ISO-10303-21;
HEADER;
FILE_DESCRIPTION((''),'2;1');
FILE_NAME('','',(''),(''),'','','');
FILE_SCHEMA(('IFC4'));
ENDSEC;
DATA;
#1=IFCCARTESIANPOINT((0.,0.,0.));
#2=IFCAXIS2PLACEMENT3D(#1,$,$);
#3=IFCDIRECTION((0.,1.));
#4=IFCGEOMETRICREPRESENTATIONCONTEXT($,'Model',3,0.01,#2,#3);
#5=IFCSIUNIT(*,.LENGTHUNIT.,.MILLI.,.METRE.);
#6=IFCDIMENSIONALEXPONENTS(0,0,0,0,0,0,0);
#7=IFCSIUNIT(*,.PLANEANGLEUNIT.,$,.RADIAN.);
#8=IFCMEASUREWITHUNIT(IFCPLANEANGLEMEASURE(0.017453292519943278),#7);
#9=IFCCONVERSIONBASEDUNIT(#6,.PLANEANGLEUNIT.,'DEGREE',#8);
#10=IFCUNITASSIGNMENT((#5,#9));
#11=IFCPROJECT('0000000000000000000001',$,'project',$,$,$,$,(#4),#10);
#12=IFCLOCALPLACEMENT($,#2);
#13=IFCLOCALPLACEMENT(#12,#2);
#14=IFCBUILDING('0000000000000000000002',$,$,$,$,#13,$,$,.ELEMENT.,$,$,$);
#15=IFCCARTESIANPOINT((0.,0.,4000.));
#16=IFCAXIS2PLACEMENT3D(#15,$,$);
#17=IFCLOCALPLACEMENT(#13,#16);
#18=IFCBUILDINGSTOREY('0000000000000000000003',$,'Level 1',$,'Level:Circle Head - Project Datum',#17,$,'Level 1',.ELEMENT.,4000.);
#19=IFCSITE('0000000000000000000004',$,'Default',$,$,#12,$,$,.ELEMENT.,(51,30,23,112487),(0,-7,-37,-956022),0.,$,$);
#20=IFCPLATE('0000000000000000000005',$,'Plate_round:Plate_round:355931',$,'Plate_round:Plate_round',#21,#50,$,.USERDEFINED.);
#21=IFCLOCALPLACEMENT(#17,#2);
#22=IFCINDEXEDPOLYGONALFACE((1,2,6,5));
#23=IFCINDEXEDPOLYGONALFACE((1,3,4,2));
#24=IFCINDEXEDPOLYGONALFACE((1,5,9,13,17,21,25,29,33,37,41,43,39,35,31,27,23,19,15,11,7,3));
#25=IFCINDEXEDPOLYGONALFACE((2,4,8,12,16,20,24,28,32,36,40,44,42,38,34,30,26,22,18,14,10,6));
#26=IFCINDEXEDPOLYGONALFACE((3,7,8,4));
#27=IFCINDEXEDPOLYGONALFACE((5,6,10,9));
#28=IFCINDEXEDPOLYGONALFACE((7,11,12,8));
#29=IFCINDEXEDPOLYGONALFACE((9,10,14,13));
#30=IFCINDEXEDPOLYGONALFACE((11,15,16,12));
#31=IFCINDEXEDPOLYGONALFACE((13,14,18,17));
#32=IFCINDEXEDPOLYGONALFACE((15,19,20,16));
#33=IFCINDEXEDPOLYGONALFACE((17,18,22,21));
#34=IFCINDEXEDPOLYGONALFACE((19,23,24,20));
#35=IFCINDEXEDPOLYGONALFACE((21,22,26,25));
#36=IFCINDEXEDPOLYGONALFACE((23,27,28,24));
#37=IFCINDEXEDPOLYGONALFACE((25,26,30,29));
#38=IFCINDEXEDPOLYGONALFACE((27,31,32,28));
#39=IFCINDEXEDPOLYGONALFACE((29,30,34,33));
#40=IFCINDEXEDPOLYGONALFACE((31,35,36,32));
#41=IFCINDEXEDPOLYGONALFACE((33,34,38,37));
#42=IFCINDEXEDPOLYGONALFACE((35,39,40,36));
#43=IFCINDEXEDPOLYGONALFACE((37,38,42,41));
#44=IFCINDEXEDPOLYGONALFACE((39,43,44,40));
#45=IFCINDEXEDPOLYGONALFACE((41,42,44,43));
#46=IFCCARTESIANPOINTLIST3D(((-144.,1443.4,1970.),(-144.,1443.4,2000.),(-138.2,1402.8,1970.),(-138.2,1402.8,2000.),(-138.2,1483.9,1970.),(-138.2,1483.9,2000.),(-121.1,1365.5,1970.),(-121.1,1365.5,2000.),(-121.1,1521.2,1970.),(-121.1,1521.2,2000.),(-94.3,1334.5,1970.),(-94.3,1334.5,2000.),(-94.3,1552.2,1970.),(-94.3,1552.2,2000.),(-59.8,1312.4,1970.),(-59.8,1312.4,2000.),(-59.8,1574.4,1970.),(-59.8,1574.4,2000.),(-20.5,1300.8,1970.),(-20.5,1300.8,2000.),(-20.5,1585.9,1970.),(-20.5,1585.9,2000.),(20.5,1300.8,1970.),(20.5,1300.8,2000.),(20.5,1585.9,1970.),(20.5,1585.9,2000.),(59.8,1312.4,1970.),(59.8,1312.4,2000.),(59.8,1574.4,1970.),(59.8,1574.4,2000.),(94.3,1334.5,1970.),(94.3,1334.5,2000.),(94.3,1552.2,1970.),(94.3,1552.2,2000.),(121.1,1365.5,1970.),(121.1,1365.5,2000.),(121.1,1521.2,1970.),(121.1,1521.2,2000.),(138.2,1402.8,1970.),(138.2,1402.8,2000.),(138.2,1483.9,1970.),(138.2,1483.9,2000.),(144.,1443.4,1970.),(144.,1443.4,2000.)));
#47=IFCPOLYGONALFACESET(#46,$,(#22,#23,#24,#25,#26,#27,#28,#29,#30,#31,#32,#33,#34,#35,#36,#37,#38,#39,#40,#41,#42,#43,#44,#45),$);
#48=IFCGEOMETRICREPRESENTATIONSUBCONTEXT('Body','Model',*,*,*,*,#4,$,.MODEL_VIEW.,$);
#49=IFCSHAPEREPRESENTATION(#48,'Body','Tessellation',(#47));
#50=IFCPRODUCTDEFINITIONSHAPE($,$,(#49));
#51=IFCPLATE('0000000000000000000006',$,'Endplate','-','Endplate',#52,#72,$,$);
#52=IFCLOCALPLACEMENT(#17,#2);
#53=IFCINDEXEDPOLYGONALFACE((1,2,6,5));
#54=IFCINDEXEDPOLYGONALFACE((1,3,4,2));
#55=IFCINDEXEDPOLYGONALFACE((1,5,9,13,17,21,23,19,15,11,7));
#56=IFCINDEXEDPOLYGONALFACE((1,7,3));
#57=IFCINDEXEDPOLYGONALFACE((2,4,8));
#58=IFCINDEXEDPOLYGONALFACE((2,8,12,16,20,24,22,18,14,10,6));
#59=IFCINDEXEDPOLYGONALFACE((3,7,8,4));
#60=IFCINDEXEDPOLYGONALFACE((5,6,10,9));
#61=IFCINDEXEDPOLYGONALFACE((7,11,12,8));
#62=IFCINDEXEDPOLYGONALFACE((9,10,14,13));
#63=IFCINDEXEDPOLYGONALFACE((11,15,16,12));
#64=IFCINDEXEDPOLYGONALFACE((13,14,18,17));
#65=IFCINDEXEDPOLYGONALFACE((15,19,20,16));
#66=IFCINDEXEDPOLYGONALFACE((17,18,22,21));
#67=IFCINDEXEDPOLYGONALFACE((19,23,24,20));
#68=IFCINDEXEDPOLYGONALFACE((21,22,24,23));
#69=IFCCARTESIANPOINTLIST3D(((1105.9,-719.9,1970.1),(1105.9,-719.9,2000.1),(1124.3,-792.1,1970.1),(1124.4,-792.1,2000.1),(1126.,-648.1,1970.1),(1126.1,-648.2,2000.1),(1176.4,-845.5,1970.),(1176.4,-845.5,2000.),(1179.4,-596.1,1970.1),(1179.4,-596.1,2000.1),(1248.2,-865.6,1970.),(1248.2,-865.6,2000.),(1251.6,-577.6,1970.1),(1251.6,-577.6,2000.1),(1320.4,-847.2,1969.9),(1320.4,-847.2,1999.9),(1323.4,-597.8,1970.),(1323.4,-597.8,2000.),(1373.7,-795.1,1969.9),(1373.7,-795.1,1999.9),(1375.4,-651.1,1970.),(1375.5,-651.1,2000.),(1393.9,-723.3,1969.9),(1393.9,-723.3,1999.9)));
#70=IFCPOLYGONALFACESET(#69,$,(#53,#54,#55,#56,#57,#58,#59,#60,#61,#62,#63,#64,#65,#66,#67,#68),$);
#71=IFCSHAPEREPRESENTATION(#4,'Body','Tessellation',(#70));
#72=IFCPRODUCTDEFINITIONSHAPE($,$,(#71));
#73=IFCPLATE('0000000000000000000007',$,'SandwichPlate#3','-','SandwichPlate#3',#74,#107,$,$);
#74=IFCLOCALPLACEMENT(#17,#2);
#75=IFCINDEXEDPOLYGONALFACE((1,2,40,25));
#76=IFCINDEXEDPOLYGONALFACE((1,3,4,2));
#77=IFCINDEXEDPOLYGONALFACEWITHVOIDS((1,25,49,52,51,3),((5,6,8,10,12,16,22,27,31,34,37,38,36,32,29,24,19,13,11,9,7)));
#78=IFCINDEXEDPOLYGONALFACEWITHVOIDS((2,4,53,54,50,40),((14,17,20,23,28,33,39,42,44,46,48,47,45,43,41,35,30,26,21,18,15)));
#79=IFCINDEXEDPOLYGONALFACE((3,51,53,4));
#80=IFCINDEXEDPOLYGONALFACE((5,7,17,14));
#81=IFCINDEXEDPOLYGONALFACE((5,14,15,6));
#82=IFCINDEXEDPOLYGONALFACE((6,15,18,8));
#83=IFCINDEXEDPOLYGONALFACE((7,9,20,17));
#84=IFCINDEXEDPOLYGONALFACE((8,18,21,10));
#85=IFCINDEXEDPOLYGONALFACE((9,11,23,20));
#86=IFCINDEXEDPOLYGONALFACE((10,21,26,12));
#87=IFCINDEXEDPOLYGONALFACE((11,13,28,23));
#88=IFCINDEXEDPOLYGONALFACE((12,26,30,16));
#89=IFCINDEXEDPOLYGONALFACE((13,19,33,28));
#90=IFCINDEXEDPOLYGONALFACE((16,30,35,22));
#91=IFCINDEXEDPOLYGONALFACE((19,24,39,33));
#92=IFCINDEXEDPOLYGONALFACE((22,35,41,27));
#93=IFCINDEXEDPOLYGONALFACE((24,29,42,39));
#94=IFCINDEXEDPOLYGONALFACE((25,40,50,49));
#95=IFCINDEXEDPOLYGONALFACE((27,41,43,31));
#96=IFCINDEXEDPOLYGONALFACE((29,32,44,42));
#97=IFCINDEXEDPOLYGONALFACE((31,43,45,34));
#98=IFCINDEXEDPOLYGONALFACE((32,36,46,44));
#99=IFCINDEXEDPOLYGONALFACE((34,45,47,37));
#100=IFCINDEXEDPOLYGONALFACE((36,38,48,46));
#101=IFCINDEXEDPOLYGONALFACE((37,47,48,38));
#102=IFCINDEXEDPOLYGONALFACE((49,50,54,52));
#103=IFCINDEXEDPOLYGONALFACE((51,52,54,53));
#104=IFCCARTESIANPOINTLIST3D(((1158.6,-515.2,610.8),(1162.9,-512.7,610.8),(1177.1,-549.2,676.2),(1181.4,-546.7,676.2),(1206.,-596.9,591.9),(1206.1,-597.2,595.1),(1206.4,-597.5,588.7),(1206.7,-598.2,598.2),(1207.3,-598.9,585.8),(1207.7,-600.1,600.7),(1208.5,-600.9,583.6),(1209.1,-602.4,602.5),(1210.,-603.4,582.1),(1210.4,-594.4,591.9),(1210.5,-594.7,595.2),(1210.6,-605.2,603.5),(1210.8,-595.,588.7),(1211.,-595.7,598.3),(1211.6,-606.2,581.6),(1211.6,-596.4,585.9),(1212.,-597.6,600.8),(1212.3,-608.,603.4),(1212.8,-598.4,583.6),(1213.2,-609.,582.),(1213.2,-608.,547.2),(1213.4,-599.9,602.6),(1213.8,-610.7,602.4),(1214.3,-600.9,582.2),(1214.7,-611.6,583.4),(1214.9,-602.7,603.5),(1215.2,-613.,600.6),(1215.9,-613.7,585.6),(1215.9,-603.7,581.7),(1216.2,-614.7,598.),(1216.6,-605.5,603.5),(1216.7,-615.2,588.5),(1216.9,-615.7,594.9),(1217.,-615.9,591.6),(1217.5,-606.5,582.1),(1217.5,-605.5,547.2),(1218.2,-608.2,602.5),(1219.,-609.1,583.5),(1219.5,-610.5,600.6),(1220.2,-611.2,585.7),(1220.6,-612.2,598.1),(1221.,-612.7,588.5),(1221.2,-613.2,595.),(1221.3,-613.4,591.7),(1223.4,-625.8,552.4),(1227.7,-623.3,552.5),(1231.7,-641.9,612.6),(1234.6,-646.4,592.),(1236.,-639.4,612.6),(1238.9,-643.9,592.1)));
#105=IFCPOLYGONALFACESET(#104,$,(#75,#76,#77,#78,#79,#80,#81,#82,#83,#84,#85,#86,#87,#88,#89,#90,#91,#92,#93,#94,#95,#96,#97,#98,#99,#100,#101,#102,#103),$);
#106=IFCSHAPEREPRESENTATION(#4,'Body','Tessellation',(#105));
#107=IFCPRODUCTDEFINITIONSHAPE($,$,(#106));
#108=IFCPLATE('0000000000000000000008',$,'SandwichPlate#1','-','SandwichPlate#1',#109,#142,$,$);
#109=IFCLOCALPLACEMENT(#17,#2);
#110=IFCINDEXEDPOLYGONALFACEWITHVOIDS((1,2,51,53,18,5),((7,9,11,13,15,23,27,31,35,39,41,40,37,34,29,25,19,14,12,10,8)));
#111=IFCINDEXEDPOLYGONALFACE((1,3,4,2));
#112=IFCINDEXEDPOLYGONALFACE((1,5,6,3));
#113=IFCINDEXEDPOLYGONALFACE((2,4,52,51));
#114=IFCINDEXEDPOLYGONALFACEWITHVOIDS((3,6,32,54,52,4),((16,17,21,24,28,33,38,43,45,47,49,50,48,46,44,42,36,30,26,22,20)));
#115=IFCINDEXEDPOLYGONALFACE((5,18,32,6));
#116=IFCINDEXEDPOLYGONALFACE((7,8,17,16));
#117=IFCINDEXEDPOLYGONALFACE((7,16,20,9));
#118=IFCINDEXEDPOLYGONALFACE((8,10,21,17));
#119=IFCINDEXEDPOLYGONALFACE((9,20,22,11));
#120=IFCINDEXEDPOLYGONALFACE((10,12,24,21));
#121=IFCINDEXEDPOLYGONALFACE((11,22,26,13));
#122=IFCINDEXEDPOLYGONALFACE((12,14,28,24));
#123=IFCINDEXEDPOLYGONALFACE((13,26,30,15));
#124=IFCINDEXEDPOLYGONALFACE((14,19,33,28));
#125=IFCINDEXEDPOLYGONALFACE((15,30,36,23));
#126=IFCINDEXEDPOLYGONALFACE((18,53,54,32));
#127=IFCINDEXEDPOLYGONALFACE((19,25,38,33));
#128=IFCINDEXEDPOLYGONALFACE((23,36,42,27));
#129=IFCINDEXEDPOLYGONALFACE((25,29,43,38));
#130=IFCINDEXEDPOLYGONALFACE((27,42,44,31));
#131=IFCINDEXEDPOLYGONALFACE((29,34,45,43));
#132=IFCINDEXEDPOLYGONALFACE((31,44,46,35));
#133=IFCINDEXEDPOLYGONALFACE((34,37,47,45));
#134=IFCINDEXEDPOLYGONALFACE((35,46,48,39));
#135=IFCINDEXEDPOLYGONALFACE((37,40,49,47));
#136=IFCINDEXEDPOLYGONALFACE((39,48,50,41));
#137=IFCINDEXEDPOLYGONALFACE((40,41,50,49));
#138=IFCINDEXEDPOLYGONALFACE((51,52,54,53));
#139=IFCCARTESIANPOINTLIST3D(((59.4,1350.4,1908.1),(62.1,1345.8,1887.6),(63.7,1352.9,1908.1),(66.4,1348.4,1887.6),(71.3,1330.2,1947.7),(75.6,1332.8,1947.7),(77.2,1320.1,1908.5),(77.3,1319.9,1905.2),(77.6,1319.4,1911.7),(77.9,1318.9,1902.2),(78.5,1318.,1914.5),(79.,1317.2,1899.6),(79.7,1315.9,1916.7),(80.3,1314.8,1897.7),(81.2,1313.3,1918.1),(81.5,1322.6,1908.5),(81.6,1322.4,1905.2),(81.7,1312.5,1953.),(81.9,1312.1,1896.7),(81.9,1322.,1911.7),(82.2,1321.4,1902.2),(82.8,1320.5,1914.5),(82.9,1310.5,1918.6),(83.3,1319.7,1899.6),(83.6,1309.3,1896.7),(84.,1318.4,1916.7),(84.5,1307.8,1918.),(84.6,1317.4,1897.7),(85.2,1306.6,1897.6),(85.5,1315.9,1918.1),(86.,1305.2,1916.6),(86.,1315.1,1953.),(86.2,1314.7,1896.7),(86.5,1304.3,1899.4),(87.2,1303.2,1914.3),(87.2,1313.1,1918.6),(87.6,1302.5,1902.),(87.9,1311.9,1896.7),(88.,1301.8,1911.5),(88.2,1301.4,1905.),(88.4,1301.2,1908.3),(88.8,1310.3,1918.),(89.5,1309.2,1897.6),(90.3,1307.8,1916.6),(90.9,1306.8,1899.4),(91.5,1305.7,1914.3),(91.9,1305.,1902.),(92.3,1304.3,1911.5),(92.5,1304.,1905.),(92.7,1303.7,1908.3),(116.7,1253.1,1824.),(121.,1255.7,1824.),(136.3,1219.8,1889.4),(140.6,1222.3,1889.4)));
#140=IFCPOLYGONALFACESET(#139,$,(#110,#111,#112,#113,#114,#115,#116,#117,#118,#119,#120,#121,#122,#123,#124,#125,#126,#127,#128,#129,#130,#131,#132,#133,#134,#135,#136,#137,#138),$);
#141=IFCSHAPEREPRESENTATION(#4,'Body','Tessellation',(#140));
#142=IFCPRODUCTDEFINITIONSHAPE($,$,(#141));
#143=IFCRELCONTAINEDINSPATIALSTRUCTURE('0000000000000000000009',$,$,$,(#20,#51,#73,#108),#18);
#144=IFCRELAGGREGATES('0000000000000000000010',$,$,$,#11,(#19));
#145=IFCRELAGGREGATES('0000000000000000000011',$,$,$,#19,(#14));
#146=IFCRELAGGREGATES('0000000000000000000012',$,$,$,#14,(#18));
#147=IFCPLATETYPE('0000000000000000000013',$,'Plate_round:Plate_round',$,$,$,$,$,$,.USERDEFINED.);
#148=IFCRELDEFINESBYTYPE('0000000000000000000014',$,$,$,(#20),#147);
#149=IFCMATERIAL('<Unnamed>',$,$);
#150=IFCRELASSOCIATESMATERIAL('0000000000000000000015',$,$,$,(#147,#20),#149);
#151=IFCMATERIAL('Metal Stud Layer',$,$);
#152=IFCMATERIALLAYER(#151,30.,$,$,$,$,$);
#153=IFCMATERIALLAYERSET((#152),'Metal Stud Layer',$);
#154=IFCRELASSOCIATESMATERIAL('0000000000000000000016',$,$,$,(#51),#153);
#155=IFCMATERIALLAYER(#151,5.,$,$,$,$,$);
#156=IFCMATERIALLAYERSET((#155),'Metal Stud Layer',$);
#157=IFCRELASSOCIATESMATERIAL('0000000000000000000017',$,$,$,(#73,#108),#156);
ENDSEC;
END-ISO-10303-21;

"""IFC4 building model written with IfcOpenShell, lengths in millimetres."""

from ifc_helpers import new_model, entity, si_unit, converted_unit, point, direction, frame, frame_2d, origin, origin_with_axes, origin_2d_with_axis, place, context, subcontext, project, spatial, polyline, arc, indexed_curve, circle_curve, line_curve, trimmed, segment, composite_curve, circle, outline, extrude, source, transform, mapped, material, layer, layer_set, type_object, type_shapes, element, save


model = new_model("IFC4")

# Units and contexts
model_context = context("Model", 3, precision=0.01, world=origin(), true_north=direction((0.0, 1.0)))
body_context = subcontext(model_context, "Body", "Model", "MODEL_VIEW")
ifc_project = project(units=[si_unit("LENGTHUNIT", "METRE", prefix="MILLI"), converted_unit("PLANEANGLEUNIT", "DEGREE", entity("IfcPlaneAngleMeasure", 0.017453292519943278), si_unit("PLANEANGLEUNIT", "RADIAN"), dimensions=[0, 0, 0, 0, 0, 0, 0])], contexts=[model_context])

# Site, building, storey
site_placement = place(None, origin())
site = spatial("IfcSite", under=ifc_project, at=site_placement, Name="Default", CompositionType="ELEMENT", RefLatitude=(51, 30, 23, 112487), RefLongitude=(0, -7, -37, -956022), RefElevation=0.0)
building_placement = place(site_placement, origin())
building = spatial("IfcBuilding", under=site, at=building_placement, CompositionType="ELEMENT")
storey_placement = place(building_placement, frame((0.0, 0.0, 4000.0)))
storey = spatial("IfcBuildingStorey", under=building, at=storey_placement, Name="Level 1", ObjectType="Level:Circle Head - Project Datum", LongName="Level 1", CompositionType="ELEMENT", Elevation=4000.0)

# Plate
ifc_material_1 = material(Name="<Unnamed>")
plate_type = type_object("IfcPlateType", Name="Plate_round:Plate_round", PredefinedType="USERDEFINED", material=ifc_material_1)
shared_shape = source(origin(), body_context, "Body", "SweptSolid", [
    extrude(outline(indexed_curve([(-144.0, 0.0), (0.0, -144.0), (144.0, 0.0), (0.0, 144.0)], segments=[arc(1, 2, 3), arc(3, 4, 1)], self_intersect=False)), origin(), (0.0, 0.0, 1.0), 30.0),
])
type_shapes(plate_type, [shared_shape])
plate_1_placement = place(storey_placement, frame((0.0, 1443.4, 1970.0)))
element("IfcPlate", 1, at=plate_1_placement, inside=storey, type_object=plate_type, material=ifc_material_1, Name="Plate_round:Plate_round:355931", ObjectType="Plate_round:Plate_round", PredefinedType="USERDEFINED", context=body_context, shape_type="MappedRepresentation", body=[
    mapped(shared_shape, transform((0.0, 0.0, 0.0), scale=1.0)),
])

# Plates, openings
ifc_material_2 = material(Name="Metal Stud Layer")
ifc_layer_1 = layer(ifc_material_2, 30.0)
ifc_layer_set_1 = layer_set([ifc_layer_1], Name="Metal Stud Layer")
plate_2_placement = place(storey_placement, frame((1323.4, -597.8, 1970.0), z_axis=(0.000702, -0.000406, 1.0), x_axis=(-0.860023, 0.510255, 0.000811)))
plate_2 = element("IfcPlate", 2, at=plate_2_placement, inside=storey, material=ifc_layer_set_1, Name="Endplate", Description="-", ObjectType="Endplate", context=model_context, shape_type="SweptSolid", body=[
    extrude(outline(polyline([(144.0, 0.0), (144.0, 288.0), (-144.0, 288.0), (-144.0, 0.0), (144.0, 0.0)])), origin_with_axes(), (0.0, 0.0, 1.0), 30.0),
])
opening_1_placement = place(plate_2_placement, frame((0.0, 0.0, 0.0), z_axis=(0.0, 0.0, 1.0), x_axis=(1.0, 0.0, 0.0)))
element("IfcOpeningElement", 3, at=opening_1_placement, cuts=plate_2, ObjectType="Opening", context=model_context, shape_type="SweptSolid", body=[
    extrude(outline(composite_curve([segment(trimmed(line_curve((144.0, 0.0), (0.0, 1.0), 144.0), [point((144.0, 0.0))], [point((144.0, 144.0))], True, "CARTESIAN"), True, "CONTINUOUS"), segment(trimmed(circle_curve(frame_2d((0.0, 144.0), x_axis=(-1.0, 0.0)), 144.0), [point((144.0, 144.0))], [point((0.0, 0.0))], False, "CARTESIAN"), True, "CONTINUOUS"), segment(trimmed(line_curve((0.0, 0.0), (1.0, 0.0), 144.0), [point((0.0, 0.0))], [point((144.0, 0.0))], True, "CARTESIAN"), True, "CONTINUOUS")], self_intersect="UNKNOWN")), origin(), (0.0, 0.0, 1.0), 30.0),
])
opening_2_placement = place(plate_2_placement, frame((0.0, 0.0, 0.0), z_axis=(0.0, 0.0, 1.0), x_axis=(1.0, 0.0, 0.0)))
element("IfcOpeningElement", 4, at=opening_2_placement, cuts=plate_2, ObjectType="Opening", context=model_context, shape_type="SweptSolid", body=[
    extrude(outline(composite_curve([segment(trimmed(line_curve((144.0, 288.0), (-1.0, 0.0), 144.0), [point((144.0, 288.0))], [point((0.0, 288.0))], True, "CARTESIAN"), True, "CONTINUOUS"), segment(trimmed(circle_curve(frame_2d((0.0, 144.0), x_axis=(-1.0, 0.0)), 144.0), [point((0.0, 288.0))], [point((144.0, 144.0))], False, "CARTESIAN"), True, "CONTINUOUS"), segment(trimmed(line_curve((144.0, 144.0), (0.0, 1.0), 144.0), [point((144.0, 144.0))], [point((144.0, 288.0))], True, "CARTESIAN"), True, "CONTINUOUS")], self_intersect="UNKNOWN")), origin(), (0.0, 0.0, 1.0), 30.0),
])
opening_3_placement = place(plate_2_placement, frame((0.0, 0.0, 0.0), z_axis=(0.0, 0.0, 1.0), x_axis=(1.0, 0.0, 0.0)))
element("IfcOpeningElement", 5, at=opening_3_placement, cuts=plate_2, ObjectType="Opening", context=model_context, shape_type="SweptSolid", body=[
    extrude(outline(composite_curve([segment(trimmed(line_curve((-144.0, 288.0), (0.0, -1.0), 144.0), [point((-144.0, 288.0))], [point((-144.0, 144.0))], True, "CARTESIAN"), True, "CONTINUOUS"), segment(trimmed(circle_curve(frame_2d((0.0, 144.0), x_axis=(-1.0, 0.0)), 144.0), [point((-144.0, 144.0))], [point((0.0, 288.0))], False, "CARTESIAN"), True, "CONTINUOUS"), segment(trimmed(line_curve((0.0, 288.0), (-1.0, 0.0), 144.0), [point((0.0, 288.0))], [point((-144.0, 288.0))], True, "CARTESIAN"), True, "CONTINUOUS")], self_intersect="UNKNOWN")), origin(), (0.0, 0.0, 1.0), 30.0),
])
opening_4_placement = place(plate_2_placement, frame((0.0, 0.0, 0.0), z_axis=(0.0, 0.0, 1.0), x_axis=(1.0, 0.0, 0.0)))
element("IfcOpeningElement", 6, at=opening_4_placement, cuts=plate_2, ObjectType="Opening", context=model_context, shape_type="SweptSolid", body=[
    extrude(outline(composite_curve([segment(trimmed(line_curve((-144.0, 0.0), (1.0, 0.0), 144.0), [point((-144.0, 0.0))], [point((0.0, 0.0))], True, "CARTESIAN"), True, "CONTINUOUS"), segment(trimmed(circle_curve(frame_2d((0.0, 144.0), x_axis=(-1.0, 0.0)), 144.0), [point((0.0, 0.0))], [point((-144.0, 144.0))], False, "CARTESIAN"), True, "CONTINUOUS"), segment(trimmed(line_curve((-144.0, 144.0), (0.0, -1.0), 144.0), [point((-144.0, 144.0))], [point((-144.0, 0.0))], True, "CARTESIAN"), True, "CONTINUOUS")], self_intersect="UNKNOWN")), origin(), (0.0, 0.0, 1.0), 30.0),
])
ifc_layer_2 = layer(ifc_material_2, 5.0)
ifc_layer_set_2 = layer_set([ifc_layer_2], Name="Metal Stud Layer")
plate_3_placement = place(storey_placement, frame((1224.1, -616.6, 539.6), z_axis=(-0.865935, -0.499948, -0.014432), x_axis=(0.243701, -0.44695, 0.860724)))
plate_3 = element("IfcPlate", 7, at=plate_3_placement, inside=storey, material=ifc_layer_set_2, Name="SandwichPlate#3", Description="-", ObjectType="SandwichPlate#3", context=model_context, shape_type="SweptSolid", body=[
    extrude(outline(polyline([(0.0, 0.0), (76.0, 0.0), (76.0, 140.0), (0.0, 140.0), (0.0, 0.0)])), origin_with_axes(), (0.0, 0.0, 1.0), 5.0),
])
opening_5_placement = place(plate_3_placement, frame((0.0, 0.0, 0.0), z_axis=(0.0, 0.0, 1.0), x_axis=(1.0, 0.0, 0.0)))
element("IfcOpeningElement", 8, at=opening_5_placement, cuts=plate_3, ObjectType="Opening", context=model_context, shape_type="SweptSolid", body=[
    extrude(outline(polyline([(0.0, 0.0), (15.0, 0.0), (0.0, 15.0), (0.0, 0.0)])), origin(), (0.0, 0.0, 1.0), 5.0),
])
opening_6_placement = place(plate_3_placement, frame((0.0, 0.0, 0.0), z_axis=(0.0, 0.0, 1.0), x_axis=(1.0, 0.0, 0.0)))
element("IfcOpeningElement", 9, at=opening_6_placement, cuts=plate_3, ObjectType="Opening", context=model_context, shape_type="SweptSolid", body=[
    extrude(outline(polyline([(76.0, 0.0), (76.0, 15.0), (61.0, 0.0), (76.0, 0.0)])), origin(), (0.0, 0.0, 1.0), 5.0),
])
opening_7_placement = place(plate_3_placement, frame((38.0, 40.0, -0.5), z_axis=(0.0, 0.0, 1.0), x_axis=(0.0, 1.0, 0.0)))
element("IfcOpeningElement", 10, at=opening_7_placement, cuts=plate_3, ObjectType="Opening", context=model_context, shape_type="SweptSolid", body=[
    extrude(circle(Radius=11.0, at=origin_2d_with_axis()), origin(), (0.0, 0.0, 1.0), 6.0),
])

# Plate, opening
plate_4_placement = place(storey_placement, frame((79.4, 1326.2, 1960.6), z_axis=(-0.861728, -0.507371, 0.0), x_axis=(-0.258184, 0.438505, -0.860845)))
plate_4 = element("IfcPlate", 11, at=plate_4_placement, inside=storey, material=ifc_layer_set_2, Name="SandwichPlate#1", Description="-", ObjectType="SandwichPlate#1", context=model_context, shape_type="SweptSolid", body=[
    extrude(outline(polyline([(15.0, 0.0), (61.0, 0.0), (76.0, 15.0), (76.0, 140.0), (0.0, 140.0), (0.0, 15.0), (15.0, 0.0)])), origin_with_axes(), (0.0, 0.0, 1.0), 5.0),
])
opening_8_placement = place(plate_4_placement, frame((38.0, 40.0, -0.5), z_axis=(0.0, 0.0, 1.0), x_axis=(0.0, 1.0, 0.0)))
element("IfcOpeningElement", 12, at=opening_8_placement, cuts=plate_4, ObjectType="Opening", context=model_context, shape_type="SweptSolid", body=[
    extrude(circle(Radius=11.0, at=origin_2d_with_axis()), origin(), (0.0, 0.0, 1.0), 6.0),
])

save(model, "model.ifc")
